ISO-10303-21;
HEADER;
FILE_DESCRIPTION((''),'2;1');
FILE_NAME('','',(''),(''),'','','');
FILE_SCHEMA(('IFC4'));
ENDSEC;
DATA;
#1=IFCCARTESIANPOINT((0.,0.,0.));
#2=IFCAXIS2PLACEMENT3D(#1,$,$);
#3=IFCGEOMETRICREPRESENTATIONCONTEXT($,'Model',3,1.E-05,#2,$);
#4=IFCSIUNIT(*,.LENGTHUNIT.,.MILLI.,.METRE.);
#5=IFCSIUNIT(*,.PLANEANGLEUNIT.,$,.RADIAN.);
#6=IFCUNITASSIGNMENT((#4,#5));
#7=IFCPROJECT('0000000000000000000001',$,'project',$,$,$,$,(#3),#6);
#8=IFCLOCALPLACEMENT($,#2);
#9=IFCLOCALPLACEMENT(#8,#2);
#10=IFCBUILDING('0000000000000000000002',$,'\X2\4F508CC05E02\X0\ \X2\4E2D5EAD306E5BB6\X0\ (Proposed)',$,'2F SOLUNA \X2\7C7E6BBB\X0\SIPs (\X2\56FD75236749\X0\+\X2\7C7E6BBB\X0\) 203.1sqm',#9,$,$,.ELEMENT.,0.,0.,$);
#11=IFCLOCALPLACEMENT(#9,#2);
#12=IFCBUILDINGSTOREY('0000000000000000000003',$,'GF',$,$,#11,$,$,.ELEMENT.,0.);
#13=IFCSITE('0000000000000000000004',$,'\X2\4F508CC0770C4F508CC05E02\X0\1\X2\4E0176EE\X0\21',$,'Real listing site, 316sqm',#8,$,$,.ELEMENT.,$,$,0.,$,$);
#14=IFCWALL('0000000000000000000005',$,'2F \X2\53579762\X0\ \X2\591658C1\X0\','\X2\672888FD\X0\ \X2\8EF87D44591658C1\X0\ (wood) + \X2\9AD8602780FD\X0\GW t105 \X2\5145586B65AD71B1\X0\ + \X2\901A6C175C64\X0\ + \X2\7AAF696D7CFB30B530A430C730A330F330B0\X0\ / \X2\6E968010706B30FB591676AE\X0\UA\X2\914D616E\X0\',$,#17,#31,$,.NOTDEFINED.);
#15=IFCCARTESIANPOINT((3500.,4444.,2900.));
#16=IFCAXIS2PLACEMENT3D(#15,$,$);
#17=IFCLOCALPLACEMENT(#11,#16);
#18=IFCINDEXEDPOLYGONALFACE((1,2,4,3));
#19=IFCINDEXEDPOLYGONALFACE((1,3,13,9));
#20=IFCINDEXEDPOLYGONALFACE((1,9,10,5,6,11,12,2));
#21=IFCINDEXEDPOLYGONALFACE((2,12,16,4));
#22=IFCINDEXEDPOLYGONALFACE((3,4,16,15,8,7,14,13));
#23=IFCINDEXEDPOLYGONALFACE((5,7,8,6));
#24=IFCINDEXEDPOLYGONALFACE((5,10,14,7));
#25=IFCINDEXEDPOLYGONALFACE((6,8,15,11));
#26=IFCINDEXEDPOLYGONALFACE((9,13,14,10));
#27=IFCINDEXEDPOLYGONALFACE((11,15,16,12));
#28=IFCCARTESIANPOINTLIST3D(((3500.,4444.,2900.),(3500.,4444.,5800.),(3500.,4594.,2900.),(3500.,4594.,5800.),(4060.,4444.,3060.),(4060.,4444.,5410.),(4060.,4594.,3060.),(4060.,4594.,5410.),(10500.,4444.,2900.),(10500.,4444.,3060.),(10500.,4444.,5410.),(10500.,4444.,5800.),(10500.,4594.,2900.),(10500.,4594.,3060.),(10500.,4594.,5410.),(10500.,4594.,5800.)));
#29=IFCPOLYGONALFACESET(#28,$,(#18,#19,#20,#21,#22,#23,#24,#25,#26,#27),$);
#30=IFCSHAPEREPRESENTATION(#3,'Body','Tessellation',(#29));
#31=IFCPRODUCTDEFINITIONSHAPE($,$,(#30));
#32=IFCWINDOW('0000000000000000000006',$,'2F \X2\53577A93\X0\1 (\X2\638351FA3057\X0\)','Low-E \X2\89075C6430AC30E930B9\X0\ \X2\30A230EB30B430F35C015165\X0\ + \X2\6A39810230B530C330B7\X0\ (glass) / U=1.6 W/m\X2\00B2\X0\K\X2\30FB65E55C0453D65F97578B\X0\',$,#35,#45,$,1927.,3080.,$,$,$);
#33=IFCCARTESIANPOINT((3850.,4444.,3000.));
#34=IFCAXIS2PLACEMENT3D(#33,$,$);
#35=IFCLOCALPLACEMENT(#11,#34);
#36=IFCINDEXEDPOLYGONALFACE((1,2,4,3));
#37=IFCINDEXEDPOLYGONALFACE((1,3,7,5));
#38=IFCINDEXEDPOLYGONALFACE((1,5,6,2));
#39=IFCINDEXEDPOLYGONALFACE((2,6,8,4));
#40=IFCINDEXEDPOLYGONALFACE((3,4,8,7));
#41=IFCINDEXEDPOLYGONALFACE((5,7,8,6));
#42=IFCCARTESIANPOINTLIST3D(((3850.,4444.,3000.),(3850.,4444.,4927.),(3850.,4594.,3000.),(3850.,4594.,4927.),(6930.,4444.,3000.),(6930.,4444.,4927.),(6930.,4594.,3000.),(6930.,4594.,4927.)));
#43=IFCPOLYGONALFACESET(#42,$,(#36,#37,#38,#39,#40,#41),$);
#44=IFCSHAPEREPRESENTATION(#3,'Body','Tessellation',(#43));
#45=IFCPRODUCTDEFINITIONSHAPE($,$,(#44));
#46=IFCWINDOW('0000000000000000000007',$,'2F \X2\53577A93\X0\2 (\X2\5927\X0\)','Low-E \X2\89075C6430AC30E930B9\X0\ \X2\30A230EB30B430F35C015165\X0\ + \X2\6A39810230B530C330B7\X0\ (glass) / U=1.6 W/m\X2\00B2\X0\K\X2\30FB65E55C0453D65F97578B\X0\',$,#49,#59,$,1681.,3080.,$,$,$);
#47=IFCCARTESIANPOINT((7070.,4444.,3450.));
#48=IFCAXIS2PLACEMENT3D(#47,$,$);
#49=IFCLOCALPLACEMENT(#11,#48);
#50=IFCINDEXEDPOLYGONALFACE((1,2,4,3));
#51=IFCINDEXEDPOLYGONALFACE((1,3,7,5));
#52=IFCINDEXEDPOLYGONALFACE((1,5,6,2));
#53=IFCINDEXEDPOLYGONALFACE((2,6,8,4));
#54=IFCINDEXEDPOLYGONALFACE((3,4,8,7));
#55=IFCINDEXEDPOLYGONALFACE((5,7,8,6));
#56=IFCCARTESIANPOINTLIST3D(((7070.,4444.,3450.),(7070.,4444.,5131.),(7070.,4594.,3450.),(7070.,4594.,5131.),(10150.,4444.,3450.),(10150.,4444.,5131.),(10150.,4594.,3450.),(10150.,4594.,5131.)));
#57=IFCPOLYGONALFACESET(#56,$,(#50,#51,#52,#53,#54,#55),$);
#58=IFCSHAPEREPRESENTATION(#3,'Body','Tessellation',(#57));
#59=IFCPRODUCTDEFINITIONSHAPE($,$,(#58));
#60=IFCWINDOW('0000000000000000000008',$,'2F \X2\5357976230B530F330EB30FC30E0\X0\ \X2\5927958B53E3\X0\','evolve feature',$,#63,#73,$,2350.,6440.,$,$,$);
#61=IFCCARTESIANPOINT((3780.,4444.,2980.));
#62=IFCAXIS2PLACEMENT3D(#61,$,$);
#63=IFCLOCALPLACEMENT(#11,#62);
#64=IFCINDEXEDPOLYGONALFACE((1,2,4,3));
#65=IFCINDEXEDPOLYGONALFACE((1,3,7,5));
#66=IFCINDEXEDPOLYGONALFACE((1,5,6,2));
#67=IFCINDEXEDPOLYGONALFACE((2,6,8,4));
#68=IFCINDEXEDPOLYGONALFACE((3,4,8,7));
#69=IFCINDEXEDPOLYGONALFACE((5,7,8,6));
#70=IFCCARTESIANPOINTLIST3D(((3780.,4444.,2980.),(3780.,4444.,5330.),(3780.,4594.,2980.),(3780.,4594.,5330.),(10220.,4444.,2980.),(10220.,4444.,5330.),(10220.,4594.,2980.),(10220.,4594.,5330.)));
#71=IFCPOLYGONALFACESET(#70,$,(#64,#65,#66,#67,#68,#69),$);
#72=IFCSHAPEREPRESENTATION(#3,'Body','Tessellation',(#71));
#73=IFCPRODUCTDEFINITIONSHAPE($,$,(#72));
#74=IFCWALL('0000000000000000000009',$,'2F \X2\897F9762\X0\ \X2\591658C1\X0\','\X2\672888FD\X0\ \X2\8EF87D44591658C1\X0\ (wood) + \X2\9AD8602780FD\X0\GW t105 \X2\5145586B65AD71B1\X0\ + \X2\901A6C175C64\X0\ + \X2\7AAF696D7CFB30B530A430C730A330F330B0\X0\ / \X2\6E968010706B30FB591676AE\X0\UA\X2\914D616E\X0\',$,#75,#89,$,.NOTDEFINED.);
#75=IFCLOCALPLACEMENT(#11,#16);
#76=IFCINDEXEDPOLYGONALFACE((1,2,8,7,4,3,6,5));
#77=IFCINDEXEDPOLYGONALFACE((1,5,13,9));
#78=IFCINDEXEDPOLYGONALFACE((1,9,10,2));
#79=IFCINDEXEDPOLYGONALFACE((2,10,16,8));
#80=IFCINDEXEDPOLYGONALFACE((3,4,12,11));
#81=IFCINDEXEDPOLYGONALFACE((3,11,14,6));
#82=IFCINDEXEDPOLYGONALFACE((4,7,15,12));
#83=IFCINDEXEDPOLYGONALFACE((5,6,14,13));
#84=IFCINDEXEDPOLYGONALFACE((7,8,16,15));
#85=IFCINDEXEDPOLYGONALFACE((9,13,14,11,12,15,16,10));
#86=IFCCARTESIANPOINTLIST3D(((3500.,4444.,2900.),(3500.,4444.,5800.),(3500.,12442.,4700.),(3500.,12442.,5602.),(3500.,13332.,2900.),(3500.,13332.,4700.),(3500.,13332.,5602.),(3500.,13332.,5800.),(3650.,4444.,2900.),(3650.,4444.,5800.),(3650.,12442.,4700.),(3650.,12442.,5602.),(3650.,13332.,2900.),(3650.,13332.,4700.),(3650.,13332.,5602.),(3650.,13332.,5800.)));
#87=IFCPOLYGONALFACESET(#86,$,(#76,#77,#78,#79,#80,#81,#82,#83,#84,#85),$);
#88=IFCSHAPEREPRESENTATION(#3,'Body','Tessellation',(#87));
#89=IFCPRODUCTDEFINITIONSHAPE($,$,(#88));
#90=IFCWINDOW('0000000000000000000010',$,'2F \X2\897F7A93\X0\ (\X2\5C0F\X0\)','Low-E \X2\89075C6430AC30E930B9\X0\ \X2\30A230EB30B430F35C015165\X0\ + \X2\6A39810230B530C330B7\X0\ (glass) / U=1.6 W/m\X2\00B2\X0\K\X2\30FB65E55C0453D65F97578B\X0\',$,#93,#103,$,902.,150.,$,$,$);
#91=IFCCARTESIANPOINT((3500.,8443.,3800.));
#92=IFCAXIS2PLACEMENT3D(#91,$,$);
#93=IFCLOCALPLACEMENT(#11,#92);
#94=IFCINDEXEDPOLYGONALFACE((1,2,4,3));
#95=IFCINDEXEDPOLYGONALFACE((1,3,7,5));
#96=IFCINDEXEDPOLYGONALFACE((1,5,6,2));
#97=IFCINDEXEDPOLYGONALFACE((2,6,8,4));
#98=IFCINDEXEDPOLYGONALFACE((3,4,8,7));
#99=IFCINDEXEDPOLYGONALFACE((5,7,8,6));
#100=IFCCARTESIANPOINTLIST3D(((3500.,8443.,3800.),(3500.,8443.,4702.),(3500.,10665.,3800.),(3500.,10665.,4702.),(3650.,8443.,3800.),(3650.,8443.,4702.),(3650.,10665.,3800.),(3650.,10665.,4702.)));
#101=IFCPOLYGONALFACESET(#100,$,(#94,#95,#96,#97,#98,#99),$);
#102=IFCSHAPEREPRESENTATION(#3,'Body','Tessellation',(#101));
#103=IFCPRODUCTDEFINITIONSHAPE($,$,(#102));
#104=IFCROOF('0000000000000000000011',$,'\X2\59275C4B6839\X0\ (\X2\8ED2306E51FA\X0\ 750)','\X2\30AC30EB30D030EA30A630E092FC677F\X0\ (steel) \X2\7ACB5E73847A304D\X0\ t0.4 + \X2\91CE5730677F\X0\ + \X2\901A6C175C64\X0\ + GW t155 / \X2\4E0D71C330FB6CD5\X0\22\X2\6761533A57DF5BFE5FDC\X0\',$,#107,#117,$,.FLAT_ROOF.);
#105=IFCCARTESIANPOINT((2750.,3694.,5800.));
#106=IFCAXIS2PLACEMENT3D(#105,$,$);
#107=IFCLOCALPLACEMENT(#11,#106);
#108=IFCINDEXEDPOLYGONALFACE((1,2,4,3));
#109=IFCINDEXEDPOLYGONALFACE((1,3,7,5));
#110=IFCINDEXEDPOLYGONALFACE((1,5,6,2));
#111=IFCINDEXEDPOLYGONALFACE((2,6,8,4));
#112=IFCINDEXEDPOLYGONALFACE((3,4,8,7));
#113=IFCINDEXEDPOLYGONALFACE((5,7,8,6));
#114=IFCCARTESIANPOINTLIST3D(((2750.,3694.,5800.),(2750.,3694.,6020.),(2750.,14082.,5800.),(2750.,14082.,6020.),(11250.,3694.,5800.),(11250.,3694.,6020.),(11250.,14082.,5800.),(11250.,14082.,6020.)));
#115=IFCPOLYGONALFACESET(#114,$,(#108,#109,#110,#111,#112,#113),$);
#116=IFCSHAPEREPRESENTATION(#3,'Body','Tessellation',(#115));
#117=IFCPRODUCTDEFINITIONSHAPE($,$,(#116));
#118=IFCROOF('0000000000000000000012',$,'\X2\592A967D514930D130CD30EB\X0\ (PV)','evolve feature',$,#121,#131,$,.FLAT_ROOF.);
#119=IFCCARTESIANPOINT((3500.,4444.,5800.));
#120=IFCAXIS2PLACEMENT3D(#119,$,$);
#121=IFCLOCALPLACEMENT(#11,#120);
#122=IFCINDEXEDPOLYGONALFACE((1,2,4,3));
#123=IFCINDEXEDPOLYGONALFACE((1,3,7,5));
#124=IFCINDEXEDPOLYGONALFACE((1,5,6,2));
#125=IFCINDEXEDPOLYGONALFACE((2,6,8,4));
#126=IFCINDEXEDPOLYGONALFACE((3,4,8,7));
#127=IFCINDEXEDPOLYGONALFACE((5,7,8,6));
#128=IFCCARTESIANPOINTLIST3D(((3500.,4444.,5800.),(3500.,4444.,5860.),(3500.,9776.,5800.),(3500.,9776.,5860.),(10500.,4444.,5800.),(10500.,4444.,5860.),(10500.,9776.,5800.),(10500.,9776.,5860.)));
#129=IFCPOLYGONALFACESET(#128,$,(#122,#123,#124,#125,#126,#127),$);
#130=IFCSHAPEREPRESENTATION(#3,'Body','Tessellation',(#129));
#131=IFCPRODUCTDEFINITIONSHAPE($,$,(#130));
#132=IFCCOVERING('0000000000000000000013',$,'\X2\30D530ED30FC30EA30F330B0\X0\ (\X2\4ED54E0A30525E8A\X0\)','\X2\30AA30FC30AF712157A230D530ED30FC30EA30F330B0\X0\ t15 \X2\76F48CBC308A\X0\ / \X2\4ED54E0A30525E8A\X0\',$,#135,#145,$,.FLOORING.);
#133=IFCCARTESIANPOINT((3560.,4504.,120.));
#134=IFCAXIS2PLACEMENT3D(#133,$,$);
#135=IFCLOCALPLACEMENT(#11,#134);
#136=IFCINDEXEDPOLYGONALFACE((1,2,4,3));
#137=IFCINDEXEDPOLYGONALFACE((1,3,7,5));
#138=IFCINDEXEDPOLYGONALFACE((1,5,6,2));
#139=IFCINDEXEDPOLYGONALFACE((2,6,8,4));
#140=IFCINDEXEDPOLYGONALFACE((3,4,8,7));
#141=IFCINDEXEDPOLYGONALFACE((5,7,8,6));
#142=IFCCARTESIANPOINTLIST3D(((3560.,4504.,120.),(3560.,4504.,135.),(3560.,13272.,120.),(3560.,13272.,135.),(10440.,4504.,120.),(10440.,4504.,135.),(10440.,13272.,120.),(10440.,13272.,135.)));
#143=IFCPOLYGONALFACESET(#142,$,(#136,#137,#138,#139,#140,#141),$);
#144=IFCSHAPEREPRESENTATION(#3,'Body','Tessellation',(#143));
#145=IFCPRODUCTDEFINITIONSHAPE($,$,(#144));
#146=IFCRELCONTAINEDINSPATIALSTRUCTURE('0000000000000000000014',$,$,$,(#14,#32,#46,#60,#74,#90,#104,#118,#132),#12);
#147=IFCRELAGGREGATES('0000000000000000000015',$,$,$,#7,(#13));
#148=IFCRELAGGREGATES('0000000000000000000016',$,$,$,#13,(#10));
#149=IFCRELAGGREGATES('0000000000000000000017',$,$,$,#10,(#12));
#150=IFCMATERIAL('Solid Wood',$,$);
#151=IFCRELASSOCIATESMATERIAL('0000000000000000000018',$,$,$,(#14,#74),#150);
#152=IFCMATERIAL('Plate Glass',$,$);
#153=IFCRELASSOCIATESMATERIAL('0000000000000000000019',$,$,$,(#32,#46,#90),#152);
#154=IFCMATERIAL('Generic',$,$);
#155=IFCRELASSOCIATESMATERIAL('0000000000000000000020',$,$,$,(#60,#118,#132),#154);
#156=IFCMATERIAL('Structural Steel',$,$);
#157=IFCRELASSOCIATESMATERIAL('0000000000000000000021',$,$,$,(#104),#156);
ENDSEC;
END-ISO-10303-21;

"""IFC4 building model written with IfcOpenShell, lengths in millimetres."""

from ifc_helpers import new_model, si_unit, frame, frame_2d, origin, place, context, project, spatial, rectangle, extrude, material, element, fill, save


model = new_model("IFC4")

# Units and contexts
model_context = context("Model", 3, precision=1e-05, world=origin())
ifc_project = project(units=[si_unit("LENGTHUNIT", "METRE", prefix="MILLI"), si_unit("PLANEANGLEUNIT", "RADIAN")], contexts=[model_context])

# Site, building, storey
site_placement = place(None, origin())
site = spatial("IfcSite", under=ifc_project, at=site_placement, Name="佐賀県佐賀市1丁目21", ObjectType="Real listing site, 316sqm", CompositionType="ELEMENT", RefElevation=0.0)
building_placement = place(site_placement, origin())
building = spatial("IfcBuilding", under=site, at=building_placement, Name="佐賀市 中庭の家 (Proposed)", ObjectType="2F SOLUNA 籾殻SIPs (国産杉+籾殻) 203.1sqm", CompositionType="ELEMENT", ElevationOfRefHeight=0.0, ElevationOfTerrain=0.0)
storey_placement = place(building_placement, origin())
storey = spatial("IfcBuildingStorey", under=building, at=storey_placement, Name="GF", CompositionType="ELEMENT", Elevation=0.0)

# Shared definitions
ifc_material_1 = material(Name="Solid Wood")
ifc_material_2 = material(Name="Generic")

# Shared definitions
ifc_material_3 = material(Name="Plate Glass")

# Wall, openings, windows
wall_1_placement = place(storey_placement, frame((3500.0, 4444.0, 2900.0)))
wall_1 = element("IfcWall", 1, at=wall_1_placement, inside=storey, material=ifc_material_1, Name="2F 南面 外壁", Description="木製 軸組外壁 (wood) + 高性能GW t105 充填断熱 + 通気層 + 窯業系サイディング / 準耐火・外皮UA配慮", PredefinedType="NOTDEFINED", context=model_context, shape_type="SweptSolid", body=[
    extrude(rectangle(XDim=7000.0, YDim=150.0, at=frame_2d((3500.0, 75.0))), frame((3500.0, 4444.0, 2900.0)), (0.0, 0.0, 1.0), 2900.0),
])
opening_1_placement = place(storey_placement, frame((3850.0, 4444.0, 3000.0)))
opening_1 = element("IfcOpeningElement", 2, at=opening_1_placement, cuts=wall_1, PredefinedType="NOTDEFINED", context=model_context, shape_type="SweptSolid", body=[
    extrude(rectangle(XDim=3080.0, YDim=150.0, at=frame_2d((1540.0, 75.0))), frame((3850.0, 4444.0, 3000.0)), (0.0, 0.0, 1.0), 1927.0),
])
opening_2_placement = place(storey_placement, frame((7070.0, 4444.0, 3450.0)))
opening_2 = element("IfcOpeningElement", 3, at=opening_2_placement, cuts=wall_1, PredefinedType="NOTDEFINED", context=model_context, shape_type="SweptSolid", body=[
    extrude(rectangle(XDim=3080.0, YDim=150.0, at=frame_2d((1540.0, 75.0))), frame((7070.0, 4444.0, 3450.0)), (0.0, 0.0, 1.0), 1681.0),
])
opening_3_placement = place(storey_placement, frame((3780.0, 4444.0, 2980.0)))
opening_3 = element("IfcOpeningElement", 4, at=opening_3_placement, cuts=wall_1, PredefinedType="NOTDEFINED", context=model_context, shape_type="SweptSolid", body=[
    extrude(rectangle(XDim=6440.0, YDim=150.0, at=frame_2d((3220.0, 75.0))), frame((3780.0, 4444.0, 2980.0)), (0.0, 0.0, 1.0), 2350.0),
])
window_1_placement = place(storey_placement, frame((3850.0, 4444.0, 3000.0)))
window_1 = element("IfcWindow", 5, at=window_1_placement, inside=storey, material=ifc_material_3, Name="2F 南窓1 (掃出し)", Description="Low-E 複層ガラス アルゴン封入 + 樹脂サッシ (glass) / U=1.6 W/m²K・日射取得型", OverallHeight=1927.0, OverallWidth=3080.0, context=model_context, shape_type="SweptSolid", body=[
    extrude(rectangle(XDim=3080.0, YDim=150.0, at=frame_2d((1540.0, 75.0))), frame((3850.0, 4444.0, 3000.0)), (0.0, 0.0, 1.0), 1927.0),
])
fill(opening_1, window_1)
window_2_placement = place(storey_placement, frame((7070.0, 4444.0, 3450.0)))
window_2 = element("IfcWindow", 6, at=window_2_placement, inside=storey, material=ifc_material_3, Name="2F 南窓2 (大)", Description="Low-E 複層ガラス アルゴン封入 + 樹脂サッシ (glass) / U=1.6 W/m²K・日射取得型", OverallHeight=1681.0, OverallWidth=3080.0, context=model_context, shape_type="SweptSolid", body=[
    extrude(rectangle(XDim=3080.0, YDim=150.0, at=frame_2d((1540.0, 75.0))), frame((7070.0, 4444.0, 3450.0)), (0.0, 0.0, 1.0), 1681.0),
])
fill(opening_2, window_2)
window_3_placement = place(storey_placement, frame((3780.0, 4444.0, 2980.0)))
window_3 = element("IfcWindow", 7, at=window_3_placement, inside=storey, material=ifc_material_2, Name="2F 南面サンルーム 大開口", Description="evolve feature", OverallHeight=2350.0, OverallWidth=6440.0, context=model_context, shape_type="SweptSolid", body=[
    extrude(rectangle(XDim=6440.0, YDim=150.0, at=frame_2d((3220.0, 75.0))), frame((3780.0, 4444.0, 2980.0)), (0.0, 0.0, 1.0), 2350.0),
])
fill(opening_3, window_3)

# Wall, opening, window
wall_2_placement = place(storey_placement, frame((3500.0, 4444.0, 2900.0)))
wall_2 = element("IfcWall", 8, at=wall_2_placement, inside=storey, material=ifc_material_1, Name="2F 西面 外壁", Description="木製 軸組外壁 (wood) + 高性能GW t105 充填断熱 + 通気層 + 窯業系サイディング / 準耐火・外皮UA配慮", PredefinedType="NOTDEFINED", context=model_context, shape_type="SweptSolid", body=[
    extrude(rectangle(XDim=150.0, YDim=8888.0, at=frame_2d((75.0, 4444.0))), frame((3500.0, 4444.0, 2900.0)), (0.0, 0.0, 1.0), 2900.0),
])
opening_4_placement = place(storey_placement, frame((3500.0, 8443.0, 3800.0)))
opening_4 = element("IfcOpeningElement", 9, at=opening_4_placement, cuts=wall_2, PredefinedType="NOTDEFINED", context=model_context, shape_type="SweptSolid", body=[
    extrude(rectangle(XDim=150.0, YDim=2222.0, at=frame_2d((75.0, 1111.0))), frame((3500.0, 8443.0, 3800.0)), (0.0, 0.0, 1.0), 902.0),
])
window_4_placement = place(storey_placement, frame((3500.0, 8443.0, 3800.0)))
window_4 = element("IfcWindow", 10, at=window_4_placement, inside=storey, material=ifc_material_3, Name="2F 西窓 (小)", Description="Low-E 複層ガラス アルゴン封入 + 樹脂サッシ (glass) / U=1.6 W/m²K・日射取得型", OverallHeight=902.0, OverallWidth=150.0, context=model_context, shape_type="SweptSolid", body=[
    extrude(rectangle(XDim=150.0, YDim=2222.0, at=frame_2d((75.0, 1111.0))), frame((3500.0, 8443.0, 3800.0)), (0.0, 0.0, 1.0), 902.0),
])
fill(opening_4, window_4)

# Roofs
ifc_material_4 = material(Name="Structural Steel")
roof_1_placement = place(storey_placement, frame((2750.0, 3694.0, 5800.0)))
element("IfcRoof", 11, at=roof_1_placement, inside=storey, material=ifc_material_4, Name="大屋根 (軒の出 750)", Description="ガルバリウム鋼板 (steel) 立平葺き t0.4 + 野地板 + 通気層 + GW t155 / 不燃・法22条区域対応", PredefinedType="FLAT_ROOF", context=model_context, shape_type="SweptSolid", body=[
    extrude(rectangle(XDim=8500.0, YDim=10388.0, at=frame_2d((4250.0, 5194.0))), frame((2750.0, 3694.0, 5800.0)), (0.0, 0.0, 1.0), 220.0),
])
roof_2_placement = place(storey_placement, frame((3500.0, 4444.0, 5800.0)))
element("IfcRoof", 12, at=roof_2_placement, inside=storey, material=ifc_material_2, Name="太陽光パネル (PV)", Description="evolve feature", PredefinedType="FLAT_ROOF", context=model_context, shape_type="SweptSolid", body=[
    extrude(rectangle(XDim=7000.0, YDim=5332.0, at=frame_2d((3500.0, 2666.0))), frame((3500.0, 4444.0, 5800.0)), (0.0, 0.0, 1.0), 60.0),
])

# Covering
covering_placement = place(storey_placement, frame((3560.0, 4504.0, 120.0)))
element("IfcCovering", 13, at=covering_placement, inside=storey, material=ifc_material_2, Name="フローリング (仕上げ床)", Description="オーク無垢フローリング t15 直貼り / 仕上げ床", PredefinedType="FLOORING", context=model_context, shape_type="SweptSolid", body=[
    extrude(rectangle(XDim=6880.0, YDim=8768.0, at=frame_2d((3440.0, 4384.0))), frame((3560.0, 4504.0, 120.0)), (0.0, 0.0, 1.0), 15.0),
])

save(model, "model.ifc")
